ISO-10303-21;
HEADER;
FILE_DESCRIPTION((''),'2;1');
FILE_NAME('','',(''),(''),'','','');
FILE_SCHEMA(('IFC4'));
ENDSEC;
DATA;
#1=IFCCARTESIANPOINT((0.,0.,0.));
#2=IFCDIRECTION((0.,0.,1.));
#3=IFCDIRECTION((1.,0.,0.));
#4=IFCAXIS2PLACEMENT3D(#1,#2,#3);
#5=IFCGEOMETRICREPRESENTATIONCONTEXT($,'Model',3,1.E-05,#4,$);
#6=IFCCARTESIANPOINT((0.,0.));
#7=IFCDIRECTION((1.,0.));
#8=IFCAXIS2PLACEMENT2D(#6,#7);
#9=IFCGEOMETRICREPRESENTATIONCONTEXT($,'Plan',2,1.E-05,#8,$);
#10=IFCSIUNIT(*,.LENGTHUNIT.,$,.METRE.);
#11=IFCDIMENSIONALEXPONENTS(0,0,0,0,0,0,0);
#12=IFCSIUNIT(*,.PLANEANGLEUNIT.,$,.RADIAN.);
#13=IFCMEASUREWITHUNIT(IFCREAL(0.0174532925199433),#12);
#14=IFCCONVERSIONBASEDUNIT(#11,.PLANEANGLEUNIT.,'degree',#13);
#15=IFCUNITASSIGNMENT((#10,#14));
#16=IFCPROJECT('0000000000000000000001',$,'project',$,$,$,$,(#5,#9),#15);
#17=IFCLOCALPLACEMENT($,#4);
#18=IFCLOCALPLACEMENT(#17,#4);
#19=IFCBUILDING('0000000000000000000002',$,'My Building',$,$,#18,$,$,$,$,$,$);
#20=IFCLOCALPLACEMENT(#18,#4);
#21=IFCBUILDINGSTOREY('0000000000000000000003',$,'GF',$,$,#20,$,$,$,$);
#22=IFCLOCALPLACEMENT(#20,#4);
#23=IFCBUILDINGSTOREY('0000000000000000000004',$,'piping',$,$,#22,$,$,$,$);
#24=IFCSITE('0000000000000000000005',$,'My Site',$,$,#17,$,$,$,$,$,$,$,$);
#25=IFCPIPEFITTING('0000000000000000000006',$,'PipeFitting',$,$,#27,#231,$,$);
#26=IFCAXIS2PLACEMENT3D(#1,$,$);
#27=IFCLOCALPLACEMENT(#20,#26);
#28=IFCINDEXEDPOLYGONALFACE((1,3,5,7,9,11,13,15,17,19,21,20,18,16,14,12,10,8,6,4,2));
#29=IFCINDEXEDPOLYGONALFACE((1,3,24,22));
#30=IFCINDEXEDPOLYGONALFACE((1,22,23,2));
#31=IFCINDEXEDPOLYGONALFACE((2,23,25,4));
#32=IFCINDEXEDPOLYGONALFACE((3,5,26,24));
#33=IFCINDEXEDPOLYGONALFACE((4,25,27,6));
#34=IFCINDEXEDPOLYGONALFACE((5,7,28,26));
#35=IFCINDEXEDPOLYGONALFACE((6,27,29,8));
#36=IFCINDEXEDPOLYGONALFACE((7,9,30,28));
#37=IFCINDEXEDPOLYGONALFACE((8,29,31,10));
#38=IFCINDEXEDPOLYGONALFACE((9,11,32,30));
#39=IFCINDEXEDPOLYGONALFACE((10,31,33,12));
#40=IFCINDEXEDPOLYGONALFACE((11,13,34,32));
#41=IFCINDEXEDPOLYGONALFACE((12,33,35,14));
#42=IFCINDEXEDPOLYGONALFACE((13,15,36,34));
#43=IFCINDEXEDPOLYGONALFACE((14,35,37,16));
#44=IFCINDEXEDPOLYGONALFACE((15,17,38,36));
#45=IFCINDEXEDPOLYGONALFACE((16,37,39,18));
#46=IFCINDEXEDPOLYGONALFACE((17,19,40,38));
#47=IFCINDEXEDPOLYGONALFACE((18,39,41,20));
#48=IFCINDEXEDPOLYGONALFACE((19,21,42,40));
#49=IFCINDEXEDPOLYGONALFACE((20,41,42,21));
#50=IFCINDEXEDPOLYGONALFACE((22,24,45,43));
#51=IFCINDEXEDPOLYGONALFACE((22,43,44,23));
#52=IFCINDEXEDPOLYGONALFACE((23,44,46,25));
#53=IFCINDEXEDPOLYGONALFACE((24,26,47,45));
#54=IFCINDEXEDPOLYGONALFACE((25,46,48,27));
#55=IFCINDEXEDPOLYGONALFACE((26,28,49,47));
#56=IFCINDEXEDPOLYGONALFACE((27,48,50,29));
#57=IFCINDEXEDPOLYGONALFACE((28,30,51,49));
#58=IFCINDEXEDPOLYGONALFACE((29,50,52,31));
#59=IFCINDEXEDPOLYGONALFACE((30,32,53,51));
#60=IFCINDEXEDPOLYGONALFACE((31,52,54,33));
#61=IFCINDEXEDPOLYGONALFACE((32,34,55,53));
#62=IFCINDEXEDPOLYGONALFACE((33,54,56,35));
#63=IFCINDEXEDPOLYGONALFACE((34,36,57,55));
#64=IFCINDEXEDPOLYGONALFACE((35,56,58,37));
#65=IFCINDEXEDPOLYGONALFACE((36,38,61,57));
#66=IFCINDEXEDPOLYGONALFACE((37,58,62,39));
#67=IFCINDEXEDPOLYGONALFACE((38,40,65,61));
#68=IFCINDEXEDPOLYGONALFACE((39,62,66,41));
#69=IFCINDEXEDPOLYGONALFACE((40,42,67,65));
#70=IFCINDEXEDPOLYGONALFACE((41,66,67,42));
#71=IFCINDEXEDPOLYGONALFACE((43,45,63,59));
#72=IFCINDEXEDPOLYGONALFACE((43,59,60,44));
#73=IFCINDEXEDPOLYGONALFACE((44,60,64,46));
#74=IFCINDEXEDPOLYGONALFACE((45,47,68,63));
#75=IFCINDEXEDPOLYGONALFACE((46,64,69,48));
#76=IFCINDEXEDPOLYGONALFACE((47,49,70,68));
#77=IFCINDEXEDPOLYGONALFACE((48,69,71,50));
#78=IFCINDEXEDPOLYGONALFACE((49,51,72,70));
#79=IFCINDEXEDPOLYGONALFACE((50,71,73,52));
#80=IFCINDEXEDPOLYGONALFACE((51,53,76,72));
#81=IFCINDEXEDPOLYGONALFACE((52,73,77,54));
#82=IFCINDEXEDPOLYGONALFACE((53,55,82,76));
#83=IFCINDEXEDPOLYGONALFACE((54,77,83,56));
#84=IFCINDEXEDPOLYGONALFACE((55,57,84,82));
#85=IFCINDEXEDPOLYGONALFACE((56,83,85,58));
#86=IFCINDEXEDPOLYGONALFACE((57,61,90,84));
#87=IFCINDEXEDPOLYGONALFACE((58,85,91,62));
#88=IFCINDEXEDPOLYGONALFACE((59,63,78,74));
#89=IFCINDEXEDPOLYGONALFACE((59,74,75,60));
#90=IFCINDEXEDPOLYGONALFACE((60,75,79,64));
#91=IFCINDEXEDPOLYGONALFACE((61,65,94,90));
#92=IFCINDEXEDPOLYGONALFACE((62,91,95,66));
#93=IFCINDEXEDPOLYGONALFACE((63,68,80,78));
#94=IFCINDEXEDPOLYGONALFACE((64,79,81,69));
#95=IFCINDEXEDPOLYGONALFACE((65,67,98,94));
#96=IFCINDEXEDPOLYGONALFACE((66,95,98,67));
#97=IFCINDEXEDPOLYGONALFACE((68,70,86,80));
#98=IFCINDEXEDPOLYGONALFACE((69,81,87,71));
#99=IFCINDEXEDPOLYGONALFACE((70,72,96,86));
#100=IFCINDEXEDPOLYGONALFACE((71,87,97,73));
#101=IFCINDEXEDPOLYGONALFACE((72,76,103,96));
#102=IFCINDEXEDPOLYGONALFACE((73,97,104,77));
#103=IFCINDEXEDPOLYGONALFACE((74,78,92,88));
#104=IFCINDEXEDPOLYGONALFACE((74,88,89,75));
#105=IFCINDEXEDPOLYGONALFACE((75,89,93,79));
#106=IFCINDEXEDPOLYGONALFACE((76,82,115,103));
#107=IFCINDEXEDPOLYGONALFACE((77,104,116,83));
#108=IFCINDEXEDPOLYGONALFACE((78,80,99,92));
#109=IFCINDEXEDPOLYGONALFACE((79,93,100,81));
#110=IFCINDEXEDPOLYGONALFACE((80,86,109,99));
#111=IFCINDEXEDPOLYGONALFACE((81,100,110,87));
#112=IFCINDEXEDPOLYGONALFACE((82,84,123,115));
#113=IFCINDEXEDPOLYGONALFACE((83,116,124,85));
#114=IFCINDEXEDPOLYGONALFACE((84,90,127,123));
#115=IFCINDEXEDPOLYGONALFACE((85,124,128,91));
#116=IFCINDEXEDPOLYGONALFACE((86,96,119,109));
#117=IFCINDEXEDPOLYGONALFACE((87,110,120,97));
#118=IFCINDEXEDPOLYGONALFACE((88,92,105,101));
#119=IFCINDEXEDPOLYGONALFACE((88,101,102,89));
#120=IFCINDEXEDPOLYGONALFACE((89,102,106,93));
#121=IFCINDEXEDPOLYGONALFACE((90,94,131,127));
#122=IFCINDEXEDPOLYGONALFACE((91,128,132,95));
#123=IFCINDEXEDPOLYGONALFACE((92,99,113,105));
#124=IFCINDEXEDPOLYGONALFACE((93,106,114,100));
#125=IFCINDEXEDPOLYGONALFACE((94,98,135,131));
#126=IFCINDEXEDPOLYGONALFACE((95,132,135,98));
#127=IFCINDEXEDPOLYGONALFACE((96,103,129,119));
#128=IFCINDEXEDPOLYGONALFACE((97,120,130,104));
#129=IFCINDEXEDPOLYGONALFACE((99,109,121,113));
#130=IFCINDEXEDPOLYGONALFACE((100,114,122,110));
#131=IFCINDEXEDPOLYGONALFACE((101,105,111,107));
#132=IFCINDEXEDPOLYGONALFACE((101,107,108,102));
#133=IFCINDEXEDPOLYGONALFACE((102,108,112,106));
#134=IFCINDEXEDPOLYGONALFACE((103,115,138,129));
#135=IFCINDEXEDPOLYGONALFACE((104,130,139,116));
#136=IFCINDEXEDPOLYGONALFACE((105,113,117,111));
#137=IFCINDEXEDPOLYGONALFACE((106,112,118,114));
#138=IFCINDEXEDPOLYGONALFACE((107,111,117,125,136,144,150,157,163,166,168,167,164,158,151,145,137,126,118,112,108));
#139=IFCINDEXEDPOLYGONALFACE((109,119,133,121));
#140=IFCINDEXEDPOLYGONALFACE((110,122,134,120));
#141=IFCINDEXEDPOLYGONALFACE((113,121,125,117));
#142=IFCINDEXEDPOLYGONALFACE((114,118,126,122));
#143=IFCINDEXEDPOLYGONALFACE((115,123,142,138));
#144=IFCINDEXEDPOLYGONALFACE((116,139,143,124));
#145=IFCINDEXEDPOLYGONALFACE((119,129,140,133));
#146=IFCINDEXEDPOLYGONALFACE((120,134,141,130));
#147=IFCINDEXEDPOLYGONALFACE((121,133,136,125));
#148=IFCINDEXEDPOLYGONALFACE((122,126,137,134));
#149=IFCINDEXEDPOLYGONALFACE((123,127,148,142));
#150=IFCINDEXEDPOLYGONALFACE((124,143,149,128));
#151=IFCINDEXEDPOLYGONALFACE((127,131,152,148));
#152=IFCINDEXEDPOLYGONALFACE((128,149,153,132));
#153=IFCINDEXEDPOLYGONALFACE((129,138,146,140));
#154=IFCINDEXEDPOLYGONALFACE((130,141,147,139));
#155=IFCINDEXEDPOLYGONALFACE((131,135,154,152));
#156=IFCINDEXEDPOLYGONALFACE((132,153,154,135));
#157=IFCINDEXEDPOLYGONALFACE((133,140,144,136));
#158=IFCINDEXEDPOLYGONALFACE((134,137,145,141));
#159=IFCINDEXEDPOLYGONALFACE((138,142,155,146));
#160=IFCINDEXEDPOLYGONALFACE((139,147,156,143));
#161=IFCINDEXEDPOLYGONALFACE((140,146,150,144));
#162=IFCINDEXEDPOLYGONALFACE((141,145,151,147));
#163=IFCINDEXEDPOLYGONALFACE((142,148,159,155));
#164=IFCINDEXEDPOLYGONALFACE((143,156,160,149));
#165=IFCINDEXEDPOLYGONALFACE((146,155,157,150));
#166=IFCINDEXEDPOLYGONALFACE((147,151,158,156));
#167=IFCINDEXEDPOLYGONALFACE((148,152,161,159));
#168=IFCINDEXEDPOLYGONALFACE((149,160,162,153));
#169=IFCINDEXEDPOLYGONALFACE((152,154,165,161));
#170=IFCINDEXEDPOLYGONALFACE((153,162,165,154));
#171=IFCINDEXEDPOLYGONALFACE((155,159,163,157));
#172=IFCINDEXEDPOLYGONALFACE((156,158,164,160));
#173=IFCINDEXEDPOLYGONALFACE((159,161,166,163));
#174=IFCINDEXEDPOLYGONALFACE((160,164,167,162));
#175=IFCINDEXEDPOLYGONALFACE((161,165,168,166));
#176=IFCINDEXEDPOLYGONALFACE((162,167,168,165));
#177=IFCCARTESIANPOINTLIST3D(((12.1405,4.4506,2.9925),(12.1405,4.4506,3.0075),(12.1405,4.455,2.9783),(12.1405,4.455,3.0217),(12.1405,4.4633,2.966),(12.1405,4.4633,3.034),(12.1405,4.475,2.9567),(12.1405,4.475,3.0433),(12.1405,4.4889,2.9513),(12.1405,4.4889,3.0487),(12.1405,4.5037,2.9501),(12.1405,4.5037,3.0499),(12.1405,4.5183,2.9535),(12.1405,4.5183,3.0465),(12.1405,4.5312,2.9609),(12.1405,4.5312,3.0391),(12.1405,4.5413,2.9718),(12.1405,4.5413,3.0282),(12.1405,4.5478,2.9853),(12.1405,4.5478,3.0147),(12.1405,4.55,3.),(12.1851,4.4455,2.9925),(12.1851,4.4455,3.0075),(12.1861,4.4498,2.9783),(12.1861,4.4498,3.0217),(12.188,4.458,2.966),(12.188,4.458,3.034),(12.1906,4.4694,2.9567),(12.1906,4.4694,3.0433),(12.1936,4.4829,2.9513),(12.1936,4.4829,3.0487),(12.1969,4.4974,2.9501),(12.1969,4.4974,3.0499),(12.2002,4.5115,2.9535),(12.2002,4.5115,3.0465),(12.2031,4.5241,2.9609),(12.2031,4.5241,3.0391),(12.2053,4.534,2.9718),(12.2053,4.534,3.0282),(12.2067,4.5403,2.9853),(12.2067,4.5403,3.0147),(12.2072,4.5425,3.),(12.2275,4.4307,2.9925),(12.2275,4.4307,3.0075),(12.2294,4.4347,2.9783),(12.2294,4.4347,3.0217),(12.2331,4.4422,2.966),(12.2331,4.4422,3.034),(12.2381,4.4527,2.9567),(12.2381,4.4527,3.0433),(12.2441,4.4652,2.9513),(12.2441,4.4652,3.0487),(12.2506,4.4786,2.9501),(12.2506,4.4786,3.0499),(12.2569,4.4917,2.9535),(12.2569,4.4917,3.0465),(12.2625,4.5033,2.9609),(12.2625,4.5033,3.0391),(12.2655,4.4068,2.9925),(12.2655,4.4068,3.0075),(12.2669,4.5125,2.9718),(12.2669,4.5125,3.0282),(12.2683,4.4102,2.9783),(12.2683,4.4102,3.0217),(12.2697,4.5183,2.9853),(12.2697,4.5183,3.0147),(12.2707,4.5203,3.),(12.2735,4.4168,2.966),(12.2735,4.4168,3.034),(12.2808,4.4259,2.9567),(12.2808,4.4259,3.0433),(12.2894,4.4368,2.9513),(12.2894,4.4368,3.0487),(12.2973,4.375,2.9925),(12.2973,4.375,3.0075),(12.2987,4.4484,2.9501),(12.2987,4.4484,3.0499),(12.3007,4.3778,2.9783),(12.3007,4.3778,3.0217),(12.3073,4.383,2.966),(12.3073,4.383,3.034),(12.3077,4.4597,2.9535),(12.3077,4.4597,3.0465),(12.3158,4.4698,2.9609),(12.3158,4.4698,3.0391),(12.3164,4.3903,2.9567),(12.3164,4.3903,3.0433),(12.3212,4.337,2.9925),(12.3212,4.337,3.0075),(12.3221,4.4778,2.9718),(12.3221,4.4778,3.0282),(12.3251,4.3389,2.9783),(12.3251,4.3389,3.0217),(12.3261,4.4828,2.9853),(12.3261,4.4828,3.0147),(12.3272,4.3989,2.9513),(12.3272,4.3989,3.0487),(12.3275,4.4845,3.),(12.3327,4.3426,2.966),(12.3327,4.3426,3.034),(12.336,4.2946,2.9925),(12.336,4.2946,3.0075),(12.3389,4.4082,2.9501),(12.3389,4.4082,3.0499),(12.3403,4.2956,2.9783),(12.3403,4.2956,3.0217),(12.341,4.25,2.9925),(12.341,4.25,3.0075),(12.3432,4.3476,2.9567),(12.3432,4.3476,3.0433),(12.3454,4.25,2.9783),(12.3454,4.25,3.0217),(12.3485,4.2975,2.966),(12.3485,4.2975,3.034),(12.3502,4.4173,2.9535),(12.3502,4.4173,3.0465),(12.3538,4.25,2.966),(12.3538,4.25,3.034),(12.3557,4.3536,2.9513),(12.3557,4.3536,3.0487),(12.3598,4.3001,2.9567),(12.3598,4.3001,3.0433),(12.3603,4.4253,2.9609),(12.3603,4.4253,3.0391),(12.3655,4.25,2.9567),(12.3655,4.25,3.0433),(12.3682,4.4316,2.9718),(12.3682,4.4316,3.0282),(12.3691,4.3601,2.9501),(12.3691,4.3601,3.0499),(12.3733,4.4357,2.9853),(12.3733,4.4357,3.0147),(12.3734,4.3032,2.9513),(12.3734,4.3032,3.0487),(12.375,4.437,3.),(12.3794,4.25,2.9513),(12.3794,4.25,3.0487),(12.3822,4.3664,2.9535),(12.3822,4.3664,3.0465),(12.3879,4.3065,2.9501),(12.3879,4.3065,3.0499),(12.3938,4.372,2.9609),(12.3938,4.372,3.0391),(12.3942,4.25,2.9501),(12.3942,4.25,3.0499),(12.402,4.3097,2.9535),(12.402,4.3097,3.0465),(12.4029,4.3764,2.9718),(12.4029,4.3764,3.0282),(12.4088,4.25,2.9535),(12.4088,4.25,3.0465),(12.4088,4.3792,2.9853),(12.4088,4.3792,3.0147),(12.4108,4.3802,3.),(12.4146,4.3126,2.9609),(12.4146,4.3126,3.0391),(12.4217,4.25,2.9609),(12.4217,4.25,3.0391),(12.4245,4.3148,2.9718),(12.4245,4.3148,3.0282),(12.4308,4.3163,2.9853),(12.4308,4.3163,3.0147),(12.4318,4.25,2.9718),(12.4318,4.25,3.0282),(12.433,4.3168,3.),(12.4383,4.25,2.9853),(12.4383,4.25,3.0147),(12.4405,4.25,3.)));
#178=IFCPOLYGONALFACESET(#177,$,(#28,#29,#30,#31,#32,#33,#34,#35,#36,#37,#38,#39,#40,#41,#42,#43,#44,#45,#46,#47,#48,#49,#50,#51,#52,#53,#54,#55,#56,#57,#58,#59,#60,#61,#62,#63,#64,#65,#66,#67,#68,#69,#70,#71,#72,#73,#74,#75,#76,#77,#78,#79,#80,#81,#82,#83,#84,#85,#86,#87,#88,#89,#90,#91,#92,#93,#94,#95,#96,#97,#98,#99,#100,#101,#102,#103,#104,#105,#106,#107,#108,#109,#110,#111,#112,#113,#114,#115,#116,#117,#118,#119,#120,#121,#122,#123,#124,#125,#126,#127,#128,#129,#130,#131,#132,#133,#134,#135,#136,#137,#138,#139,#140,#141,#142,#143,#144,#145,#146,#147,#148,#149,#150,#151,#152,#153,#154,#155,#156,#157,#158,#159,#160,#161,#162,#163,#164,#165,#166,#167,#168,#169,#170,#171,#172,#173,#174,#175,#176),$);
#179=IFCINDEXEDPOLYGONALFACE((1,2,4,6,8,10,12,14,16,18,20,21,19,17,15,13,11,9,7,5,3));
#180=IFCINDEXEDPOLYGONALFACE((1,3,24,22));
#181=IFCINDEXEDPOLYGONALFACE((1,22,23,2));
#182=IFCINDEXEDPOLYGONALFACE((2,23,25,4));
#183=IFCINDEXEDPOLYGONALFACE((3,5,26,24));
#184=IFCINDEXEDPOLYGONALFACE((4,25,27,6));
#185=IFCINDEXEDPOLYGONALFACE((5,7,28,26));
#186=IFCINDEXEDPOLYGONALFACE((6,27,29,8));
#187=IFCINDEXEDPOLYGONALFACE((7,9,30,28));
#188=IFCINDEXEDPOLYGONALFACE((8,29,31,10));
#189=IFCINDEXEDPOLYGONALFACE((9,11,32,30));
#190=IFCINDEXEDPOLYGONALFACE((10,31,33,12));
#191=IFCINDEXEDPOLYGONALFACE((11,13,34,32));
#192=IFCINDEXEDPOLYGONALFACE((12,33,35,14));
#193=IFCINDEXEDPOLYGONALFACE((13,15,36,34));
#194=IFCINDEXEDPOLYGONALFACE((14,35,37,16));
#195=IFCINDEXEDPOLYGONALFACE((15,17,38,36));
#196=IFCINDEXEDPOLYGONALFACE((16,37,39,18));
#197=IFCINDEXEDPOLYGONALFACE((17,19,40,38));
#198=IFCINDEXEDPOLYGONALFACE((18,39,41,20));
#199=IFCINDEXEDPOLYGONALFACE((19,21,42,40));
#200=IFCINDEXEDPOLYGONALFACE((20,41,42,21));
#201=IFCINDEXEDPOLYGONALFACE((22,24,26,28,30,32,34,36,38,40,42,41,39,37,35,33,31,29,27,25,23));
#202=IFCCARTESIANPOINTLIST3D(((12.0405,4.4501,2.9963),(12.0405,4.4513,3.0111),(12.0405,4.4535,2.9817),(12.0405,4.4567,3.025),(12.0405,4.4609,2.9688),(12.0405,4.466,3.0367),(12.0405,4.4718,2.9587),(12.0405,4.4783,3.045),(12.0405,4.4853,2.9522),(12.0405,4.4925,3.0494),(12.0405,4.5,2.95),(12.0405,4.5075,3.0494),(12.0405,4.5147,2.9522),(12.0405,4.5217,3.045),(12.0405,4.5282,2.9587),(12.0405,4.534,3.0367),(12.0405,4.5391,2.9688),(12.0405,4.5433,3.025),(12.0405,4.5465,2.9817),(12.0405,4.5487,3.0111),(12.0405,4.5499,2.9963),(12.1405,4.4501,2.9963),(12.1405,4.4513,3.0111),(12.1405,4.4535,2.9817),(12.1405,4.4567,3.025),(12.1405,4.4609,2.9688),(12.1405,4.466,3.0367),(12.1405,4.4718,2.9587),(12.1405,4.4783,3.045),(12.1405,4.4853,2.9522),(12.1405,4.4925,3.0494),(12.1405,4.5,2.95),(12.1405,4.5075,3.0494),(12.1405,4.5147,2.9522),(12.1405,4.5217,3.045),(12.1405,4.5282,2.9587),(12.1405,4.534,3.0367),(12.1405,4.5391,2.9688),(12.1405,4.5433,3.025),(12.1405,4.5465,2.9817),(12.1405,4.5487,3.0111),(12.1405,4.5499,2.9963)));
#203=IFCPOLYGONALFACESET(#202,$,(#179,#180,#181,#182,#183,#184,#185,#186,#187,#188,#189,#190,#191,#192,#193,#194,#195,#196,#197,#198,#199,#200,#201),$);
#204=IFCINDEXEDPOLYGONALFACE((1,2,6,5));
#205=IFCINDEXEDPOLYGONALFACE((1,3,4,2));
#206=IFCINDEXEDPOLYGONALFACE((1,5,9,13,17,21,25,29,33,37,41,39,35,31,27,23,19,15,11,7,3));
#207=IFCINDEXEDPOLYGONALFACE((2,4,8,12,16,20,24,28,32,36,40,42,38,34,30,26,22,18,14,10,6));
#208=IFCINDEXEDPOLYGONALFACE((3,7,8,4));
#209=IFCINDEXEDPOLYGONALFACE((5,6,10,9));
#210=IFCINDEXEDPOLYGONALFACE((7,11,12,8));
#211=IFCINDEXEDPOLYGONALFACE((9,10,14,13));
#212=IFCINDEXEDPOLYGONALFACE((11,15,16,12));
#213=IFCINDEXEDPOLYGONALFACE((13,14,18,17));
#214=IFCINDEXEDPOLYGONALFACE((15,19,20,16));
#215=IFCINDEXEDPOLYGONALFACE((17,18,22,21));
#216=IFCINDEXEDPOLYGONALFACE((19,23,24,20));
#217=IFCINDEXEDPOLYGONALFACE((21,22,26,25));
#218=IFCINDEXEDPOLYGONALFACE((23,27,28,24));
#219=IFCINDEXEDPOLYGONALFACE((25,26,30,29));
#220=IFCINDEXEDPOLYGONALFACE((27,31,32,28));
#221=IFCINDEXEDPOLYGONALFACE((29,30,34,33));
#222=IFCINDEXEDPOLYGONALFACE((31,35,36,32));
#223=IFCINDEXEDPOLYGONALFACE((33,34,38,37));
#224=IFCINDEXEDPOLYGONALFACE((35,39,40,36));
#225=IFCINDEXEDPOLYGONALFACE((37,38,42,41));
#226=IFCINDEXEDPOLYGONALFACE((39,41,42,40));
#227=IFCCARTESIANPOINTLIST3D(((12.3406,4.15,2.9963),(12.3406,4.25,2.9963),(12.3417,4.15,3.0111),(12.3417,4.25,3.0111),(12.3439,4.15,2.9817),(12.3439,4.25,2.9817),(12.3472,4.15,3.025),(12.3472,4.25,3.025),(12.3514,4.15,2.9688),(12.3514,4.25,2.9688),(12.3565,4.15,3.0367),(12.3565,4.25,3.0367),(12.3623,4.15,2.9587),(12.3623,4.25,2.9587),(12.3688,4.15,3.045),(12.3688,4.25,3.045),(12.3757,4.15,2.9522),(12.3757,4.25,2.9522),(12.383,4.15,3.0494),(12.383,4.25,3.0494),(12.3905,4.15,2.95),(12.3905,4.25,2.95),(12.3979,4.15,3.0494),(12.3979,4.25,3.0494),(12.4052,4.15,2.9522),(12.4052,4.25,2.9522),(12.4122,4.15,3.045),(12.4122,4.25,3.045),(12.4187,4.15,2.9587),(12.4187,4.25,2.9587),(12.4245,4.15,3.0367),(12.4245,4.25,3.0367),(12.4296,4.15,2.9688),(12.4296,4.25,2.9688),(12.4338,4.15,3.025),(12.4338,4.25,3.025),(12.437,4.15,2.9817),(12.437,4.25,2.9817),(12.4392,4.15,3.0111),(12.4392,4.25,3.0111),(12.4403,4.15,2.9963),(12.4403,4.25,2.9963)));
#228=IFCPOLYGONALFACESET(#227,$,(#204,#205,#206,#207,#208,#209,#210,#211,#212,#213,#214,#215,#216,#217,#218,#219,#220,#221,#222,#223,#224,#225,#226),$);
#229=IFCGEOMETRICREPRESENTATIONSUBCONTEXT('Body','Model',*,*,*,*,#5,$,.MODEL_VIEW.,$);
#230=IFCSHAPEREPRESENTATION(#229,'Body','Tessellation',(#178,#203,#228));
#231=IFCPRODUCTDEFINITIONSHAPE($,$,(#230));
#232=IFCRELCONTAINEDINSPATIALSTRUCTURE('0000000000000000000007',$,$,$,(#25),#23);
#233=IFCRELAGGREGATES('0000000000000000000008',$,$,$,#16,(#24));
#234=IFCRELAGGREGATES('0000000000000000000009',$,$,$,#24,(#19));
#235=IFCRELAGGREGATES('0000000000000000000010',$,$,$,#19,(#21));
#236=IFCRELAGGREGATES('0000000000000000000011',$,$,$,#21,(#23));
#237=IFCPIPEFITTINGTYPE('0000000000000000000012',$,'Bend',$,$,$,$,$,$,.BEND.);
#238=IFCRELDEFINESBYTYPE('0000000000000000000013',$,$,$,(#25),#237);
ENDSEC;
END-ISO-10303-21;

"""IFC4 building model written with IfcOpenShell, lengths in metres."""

from ifc_helpers import new_model, entity, si_unit, converted_unit, frame, origin_with_axes, origin_2d_with_axis, place, context, subcontext, project, spatial, circle, extrude, source, transform, mapped, type_object, type_shapes, element, save


model = new_model("IFC4")

# Units and contexts
model_context = context("Model", 3, precision=1e-05, world=origin_with_axes())
plan_context = context("Plan", 2, precision=1e-05, world=origin_2d_with_axis())
body_context = subcontext(model_context, "Body", "Model", "MODEL_VIEW")
ifc_project = project(units=[si_unit("LENGTHUNIT", "METRE"), converted_unit("PLANEANGLEUNIT", "degree", entity("IfcReal", 0.0174532925199433), si_unit("PLANEANGLEUNIT", "RADIAN"), dimensions=[0, 0, 0, 0, 0, 0, 0])], contexts=[model_context, plan_context])

# Site, building, storeys
site_placement = place(None, origin_with_axes())
site = spatial("IfcSite", under=ifc_project, at=site_placement, Name="My Site")
building_placement = place(site_placement, origin_with_axes())
building = spatial("IfcBuilding", under=site, at=building_placement, Name="My Building")
storey_1_placement = place(building_placement, origin_with_axes())
storey_1 = spatial("IfcBuildingStorey", under=building, at=storey_1_placement, Name="GF")
storey_2_placement = place(storey_1_placement, origin_with_axes())
storey_2 = spatial("IfcBuildingStorey", under=storey_1, at=storey_2_placement, Name="piping")

# Pipe fitting
pipe_fitting_type = type_object("IfcPipeFittingType", Name="Bend", PredefinedType="BEND")
shared_shape = source(origin_with_axes(), body_context, "Body", "SolidModel", [
    entity("IfcSweptDiskSolid", entity("IfcIndexedPolyCurve", entity("IfcCartesianPointList3D", [[0.0, 0.0, 0.1], [0.0, -0.0732, 0.2768], [0.0, -0.25, 0.35]]), [entity("IfcArcIndex", [1, 2, 3])]), 0.05),
    extrude(circle(Radius=0.05), origin_with_axes(), (0.0, 0.0, 1.0), 0.1),
    extrude(circle(Radius=0.05), frame((0.0, -0.25, 0.35), z_axis=(0.0, -1.0, 0.0), x_axis=(1.0, 0.0, 0.0)), (0.0, 0.0, 1.0), 0.1),
])
type_shapes(pipe_fitting_type, [shared_shape])
for number, where, z_axis, x_axis, name in (
    (1, (12.0405, 4.5, 3.0), (1.0, 0.0, 0.0), (0.0, 0.0, -1.0), "PipeFitting"),
):
    element("IfcPipeFitting", number, at=place(storey_2_placement, frame(where, z_axis=z_axis, x_axis=x_axis)), inside=storey_2, type_object=pipe_fitting_type, Name=name, context=body_context, shape_type="MappedRepresentation", body=[
        mapped(shared_shape, transform((0.0, 0.0, 0.0), x_axis=(1.0, 0.0, 0.0), y_axis=(0.0, 1.0, 0.0), z_axis=(0.0, 0.0, 1.0), scale=1.0)),
    ])

save(model, "model.ifc")
